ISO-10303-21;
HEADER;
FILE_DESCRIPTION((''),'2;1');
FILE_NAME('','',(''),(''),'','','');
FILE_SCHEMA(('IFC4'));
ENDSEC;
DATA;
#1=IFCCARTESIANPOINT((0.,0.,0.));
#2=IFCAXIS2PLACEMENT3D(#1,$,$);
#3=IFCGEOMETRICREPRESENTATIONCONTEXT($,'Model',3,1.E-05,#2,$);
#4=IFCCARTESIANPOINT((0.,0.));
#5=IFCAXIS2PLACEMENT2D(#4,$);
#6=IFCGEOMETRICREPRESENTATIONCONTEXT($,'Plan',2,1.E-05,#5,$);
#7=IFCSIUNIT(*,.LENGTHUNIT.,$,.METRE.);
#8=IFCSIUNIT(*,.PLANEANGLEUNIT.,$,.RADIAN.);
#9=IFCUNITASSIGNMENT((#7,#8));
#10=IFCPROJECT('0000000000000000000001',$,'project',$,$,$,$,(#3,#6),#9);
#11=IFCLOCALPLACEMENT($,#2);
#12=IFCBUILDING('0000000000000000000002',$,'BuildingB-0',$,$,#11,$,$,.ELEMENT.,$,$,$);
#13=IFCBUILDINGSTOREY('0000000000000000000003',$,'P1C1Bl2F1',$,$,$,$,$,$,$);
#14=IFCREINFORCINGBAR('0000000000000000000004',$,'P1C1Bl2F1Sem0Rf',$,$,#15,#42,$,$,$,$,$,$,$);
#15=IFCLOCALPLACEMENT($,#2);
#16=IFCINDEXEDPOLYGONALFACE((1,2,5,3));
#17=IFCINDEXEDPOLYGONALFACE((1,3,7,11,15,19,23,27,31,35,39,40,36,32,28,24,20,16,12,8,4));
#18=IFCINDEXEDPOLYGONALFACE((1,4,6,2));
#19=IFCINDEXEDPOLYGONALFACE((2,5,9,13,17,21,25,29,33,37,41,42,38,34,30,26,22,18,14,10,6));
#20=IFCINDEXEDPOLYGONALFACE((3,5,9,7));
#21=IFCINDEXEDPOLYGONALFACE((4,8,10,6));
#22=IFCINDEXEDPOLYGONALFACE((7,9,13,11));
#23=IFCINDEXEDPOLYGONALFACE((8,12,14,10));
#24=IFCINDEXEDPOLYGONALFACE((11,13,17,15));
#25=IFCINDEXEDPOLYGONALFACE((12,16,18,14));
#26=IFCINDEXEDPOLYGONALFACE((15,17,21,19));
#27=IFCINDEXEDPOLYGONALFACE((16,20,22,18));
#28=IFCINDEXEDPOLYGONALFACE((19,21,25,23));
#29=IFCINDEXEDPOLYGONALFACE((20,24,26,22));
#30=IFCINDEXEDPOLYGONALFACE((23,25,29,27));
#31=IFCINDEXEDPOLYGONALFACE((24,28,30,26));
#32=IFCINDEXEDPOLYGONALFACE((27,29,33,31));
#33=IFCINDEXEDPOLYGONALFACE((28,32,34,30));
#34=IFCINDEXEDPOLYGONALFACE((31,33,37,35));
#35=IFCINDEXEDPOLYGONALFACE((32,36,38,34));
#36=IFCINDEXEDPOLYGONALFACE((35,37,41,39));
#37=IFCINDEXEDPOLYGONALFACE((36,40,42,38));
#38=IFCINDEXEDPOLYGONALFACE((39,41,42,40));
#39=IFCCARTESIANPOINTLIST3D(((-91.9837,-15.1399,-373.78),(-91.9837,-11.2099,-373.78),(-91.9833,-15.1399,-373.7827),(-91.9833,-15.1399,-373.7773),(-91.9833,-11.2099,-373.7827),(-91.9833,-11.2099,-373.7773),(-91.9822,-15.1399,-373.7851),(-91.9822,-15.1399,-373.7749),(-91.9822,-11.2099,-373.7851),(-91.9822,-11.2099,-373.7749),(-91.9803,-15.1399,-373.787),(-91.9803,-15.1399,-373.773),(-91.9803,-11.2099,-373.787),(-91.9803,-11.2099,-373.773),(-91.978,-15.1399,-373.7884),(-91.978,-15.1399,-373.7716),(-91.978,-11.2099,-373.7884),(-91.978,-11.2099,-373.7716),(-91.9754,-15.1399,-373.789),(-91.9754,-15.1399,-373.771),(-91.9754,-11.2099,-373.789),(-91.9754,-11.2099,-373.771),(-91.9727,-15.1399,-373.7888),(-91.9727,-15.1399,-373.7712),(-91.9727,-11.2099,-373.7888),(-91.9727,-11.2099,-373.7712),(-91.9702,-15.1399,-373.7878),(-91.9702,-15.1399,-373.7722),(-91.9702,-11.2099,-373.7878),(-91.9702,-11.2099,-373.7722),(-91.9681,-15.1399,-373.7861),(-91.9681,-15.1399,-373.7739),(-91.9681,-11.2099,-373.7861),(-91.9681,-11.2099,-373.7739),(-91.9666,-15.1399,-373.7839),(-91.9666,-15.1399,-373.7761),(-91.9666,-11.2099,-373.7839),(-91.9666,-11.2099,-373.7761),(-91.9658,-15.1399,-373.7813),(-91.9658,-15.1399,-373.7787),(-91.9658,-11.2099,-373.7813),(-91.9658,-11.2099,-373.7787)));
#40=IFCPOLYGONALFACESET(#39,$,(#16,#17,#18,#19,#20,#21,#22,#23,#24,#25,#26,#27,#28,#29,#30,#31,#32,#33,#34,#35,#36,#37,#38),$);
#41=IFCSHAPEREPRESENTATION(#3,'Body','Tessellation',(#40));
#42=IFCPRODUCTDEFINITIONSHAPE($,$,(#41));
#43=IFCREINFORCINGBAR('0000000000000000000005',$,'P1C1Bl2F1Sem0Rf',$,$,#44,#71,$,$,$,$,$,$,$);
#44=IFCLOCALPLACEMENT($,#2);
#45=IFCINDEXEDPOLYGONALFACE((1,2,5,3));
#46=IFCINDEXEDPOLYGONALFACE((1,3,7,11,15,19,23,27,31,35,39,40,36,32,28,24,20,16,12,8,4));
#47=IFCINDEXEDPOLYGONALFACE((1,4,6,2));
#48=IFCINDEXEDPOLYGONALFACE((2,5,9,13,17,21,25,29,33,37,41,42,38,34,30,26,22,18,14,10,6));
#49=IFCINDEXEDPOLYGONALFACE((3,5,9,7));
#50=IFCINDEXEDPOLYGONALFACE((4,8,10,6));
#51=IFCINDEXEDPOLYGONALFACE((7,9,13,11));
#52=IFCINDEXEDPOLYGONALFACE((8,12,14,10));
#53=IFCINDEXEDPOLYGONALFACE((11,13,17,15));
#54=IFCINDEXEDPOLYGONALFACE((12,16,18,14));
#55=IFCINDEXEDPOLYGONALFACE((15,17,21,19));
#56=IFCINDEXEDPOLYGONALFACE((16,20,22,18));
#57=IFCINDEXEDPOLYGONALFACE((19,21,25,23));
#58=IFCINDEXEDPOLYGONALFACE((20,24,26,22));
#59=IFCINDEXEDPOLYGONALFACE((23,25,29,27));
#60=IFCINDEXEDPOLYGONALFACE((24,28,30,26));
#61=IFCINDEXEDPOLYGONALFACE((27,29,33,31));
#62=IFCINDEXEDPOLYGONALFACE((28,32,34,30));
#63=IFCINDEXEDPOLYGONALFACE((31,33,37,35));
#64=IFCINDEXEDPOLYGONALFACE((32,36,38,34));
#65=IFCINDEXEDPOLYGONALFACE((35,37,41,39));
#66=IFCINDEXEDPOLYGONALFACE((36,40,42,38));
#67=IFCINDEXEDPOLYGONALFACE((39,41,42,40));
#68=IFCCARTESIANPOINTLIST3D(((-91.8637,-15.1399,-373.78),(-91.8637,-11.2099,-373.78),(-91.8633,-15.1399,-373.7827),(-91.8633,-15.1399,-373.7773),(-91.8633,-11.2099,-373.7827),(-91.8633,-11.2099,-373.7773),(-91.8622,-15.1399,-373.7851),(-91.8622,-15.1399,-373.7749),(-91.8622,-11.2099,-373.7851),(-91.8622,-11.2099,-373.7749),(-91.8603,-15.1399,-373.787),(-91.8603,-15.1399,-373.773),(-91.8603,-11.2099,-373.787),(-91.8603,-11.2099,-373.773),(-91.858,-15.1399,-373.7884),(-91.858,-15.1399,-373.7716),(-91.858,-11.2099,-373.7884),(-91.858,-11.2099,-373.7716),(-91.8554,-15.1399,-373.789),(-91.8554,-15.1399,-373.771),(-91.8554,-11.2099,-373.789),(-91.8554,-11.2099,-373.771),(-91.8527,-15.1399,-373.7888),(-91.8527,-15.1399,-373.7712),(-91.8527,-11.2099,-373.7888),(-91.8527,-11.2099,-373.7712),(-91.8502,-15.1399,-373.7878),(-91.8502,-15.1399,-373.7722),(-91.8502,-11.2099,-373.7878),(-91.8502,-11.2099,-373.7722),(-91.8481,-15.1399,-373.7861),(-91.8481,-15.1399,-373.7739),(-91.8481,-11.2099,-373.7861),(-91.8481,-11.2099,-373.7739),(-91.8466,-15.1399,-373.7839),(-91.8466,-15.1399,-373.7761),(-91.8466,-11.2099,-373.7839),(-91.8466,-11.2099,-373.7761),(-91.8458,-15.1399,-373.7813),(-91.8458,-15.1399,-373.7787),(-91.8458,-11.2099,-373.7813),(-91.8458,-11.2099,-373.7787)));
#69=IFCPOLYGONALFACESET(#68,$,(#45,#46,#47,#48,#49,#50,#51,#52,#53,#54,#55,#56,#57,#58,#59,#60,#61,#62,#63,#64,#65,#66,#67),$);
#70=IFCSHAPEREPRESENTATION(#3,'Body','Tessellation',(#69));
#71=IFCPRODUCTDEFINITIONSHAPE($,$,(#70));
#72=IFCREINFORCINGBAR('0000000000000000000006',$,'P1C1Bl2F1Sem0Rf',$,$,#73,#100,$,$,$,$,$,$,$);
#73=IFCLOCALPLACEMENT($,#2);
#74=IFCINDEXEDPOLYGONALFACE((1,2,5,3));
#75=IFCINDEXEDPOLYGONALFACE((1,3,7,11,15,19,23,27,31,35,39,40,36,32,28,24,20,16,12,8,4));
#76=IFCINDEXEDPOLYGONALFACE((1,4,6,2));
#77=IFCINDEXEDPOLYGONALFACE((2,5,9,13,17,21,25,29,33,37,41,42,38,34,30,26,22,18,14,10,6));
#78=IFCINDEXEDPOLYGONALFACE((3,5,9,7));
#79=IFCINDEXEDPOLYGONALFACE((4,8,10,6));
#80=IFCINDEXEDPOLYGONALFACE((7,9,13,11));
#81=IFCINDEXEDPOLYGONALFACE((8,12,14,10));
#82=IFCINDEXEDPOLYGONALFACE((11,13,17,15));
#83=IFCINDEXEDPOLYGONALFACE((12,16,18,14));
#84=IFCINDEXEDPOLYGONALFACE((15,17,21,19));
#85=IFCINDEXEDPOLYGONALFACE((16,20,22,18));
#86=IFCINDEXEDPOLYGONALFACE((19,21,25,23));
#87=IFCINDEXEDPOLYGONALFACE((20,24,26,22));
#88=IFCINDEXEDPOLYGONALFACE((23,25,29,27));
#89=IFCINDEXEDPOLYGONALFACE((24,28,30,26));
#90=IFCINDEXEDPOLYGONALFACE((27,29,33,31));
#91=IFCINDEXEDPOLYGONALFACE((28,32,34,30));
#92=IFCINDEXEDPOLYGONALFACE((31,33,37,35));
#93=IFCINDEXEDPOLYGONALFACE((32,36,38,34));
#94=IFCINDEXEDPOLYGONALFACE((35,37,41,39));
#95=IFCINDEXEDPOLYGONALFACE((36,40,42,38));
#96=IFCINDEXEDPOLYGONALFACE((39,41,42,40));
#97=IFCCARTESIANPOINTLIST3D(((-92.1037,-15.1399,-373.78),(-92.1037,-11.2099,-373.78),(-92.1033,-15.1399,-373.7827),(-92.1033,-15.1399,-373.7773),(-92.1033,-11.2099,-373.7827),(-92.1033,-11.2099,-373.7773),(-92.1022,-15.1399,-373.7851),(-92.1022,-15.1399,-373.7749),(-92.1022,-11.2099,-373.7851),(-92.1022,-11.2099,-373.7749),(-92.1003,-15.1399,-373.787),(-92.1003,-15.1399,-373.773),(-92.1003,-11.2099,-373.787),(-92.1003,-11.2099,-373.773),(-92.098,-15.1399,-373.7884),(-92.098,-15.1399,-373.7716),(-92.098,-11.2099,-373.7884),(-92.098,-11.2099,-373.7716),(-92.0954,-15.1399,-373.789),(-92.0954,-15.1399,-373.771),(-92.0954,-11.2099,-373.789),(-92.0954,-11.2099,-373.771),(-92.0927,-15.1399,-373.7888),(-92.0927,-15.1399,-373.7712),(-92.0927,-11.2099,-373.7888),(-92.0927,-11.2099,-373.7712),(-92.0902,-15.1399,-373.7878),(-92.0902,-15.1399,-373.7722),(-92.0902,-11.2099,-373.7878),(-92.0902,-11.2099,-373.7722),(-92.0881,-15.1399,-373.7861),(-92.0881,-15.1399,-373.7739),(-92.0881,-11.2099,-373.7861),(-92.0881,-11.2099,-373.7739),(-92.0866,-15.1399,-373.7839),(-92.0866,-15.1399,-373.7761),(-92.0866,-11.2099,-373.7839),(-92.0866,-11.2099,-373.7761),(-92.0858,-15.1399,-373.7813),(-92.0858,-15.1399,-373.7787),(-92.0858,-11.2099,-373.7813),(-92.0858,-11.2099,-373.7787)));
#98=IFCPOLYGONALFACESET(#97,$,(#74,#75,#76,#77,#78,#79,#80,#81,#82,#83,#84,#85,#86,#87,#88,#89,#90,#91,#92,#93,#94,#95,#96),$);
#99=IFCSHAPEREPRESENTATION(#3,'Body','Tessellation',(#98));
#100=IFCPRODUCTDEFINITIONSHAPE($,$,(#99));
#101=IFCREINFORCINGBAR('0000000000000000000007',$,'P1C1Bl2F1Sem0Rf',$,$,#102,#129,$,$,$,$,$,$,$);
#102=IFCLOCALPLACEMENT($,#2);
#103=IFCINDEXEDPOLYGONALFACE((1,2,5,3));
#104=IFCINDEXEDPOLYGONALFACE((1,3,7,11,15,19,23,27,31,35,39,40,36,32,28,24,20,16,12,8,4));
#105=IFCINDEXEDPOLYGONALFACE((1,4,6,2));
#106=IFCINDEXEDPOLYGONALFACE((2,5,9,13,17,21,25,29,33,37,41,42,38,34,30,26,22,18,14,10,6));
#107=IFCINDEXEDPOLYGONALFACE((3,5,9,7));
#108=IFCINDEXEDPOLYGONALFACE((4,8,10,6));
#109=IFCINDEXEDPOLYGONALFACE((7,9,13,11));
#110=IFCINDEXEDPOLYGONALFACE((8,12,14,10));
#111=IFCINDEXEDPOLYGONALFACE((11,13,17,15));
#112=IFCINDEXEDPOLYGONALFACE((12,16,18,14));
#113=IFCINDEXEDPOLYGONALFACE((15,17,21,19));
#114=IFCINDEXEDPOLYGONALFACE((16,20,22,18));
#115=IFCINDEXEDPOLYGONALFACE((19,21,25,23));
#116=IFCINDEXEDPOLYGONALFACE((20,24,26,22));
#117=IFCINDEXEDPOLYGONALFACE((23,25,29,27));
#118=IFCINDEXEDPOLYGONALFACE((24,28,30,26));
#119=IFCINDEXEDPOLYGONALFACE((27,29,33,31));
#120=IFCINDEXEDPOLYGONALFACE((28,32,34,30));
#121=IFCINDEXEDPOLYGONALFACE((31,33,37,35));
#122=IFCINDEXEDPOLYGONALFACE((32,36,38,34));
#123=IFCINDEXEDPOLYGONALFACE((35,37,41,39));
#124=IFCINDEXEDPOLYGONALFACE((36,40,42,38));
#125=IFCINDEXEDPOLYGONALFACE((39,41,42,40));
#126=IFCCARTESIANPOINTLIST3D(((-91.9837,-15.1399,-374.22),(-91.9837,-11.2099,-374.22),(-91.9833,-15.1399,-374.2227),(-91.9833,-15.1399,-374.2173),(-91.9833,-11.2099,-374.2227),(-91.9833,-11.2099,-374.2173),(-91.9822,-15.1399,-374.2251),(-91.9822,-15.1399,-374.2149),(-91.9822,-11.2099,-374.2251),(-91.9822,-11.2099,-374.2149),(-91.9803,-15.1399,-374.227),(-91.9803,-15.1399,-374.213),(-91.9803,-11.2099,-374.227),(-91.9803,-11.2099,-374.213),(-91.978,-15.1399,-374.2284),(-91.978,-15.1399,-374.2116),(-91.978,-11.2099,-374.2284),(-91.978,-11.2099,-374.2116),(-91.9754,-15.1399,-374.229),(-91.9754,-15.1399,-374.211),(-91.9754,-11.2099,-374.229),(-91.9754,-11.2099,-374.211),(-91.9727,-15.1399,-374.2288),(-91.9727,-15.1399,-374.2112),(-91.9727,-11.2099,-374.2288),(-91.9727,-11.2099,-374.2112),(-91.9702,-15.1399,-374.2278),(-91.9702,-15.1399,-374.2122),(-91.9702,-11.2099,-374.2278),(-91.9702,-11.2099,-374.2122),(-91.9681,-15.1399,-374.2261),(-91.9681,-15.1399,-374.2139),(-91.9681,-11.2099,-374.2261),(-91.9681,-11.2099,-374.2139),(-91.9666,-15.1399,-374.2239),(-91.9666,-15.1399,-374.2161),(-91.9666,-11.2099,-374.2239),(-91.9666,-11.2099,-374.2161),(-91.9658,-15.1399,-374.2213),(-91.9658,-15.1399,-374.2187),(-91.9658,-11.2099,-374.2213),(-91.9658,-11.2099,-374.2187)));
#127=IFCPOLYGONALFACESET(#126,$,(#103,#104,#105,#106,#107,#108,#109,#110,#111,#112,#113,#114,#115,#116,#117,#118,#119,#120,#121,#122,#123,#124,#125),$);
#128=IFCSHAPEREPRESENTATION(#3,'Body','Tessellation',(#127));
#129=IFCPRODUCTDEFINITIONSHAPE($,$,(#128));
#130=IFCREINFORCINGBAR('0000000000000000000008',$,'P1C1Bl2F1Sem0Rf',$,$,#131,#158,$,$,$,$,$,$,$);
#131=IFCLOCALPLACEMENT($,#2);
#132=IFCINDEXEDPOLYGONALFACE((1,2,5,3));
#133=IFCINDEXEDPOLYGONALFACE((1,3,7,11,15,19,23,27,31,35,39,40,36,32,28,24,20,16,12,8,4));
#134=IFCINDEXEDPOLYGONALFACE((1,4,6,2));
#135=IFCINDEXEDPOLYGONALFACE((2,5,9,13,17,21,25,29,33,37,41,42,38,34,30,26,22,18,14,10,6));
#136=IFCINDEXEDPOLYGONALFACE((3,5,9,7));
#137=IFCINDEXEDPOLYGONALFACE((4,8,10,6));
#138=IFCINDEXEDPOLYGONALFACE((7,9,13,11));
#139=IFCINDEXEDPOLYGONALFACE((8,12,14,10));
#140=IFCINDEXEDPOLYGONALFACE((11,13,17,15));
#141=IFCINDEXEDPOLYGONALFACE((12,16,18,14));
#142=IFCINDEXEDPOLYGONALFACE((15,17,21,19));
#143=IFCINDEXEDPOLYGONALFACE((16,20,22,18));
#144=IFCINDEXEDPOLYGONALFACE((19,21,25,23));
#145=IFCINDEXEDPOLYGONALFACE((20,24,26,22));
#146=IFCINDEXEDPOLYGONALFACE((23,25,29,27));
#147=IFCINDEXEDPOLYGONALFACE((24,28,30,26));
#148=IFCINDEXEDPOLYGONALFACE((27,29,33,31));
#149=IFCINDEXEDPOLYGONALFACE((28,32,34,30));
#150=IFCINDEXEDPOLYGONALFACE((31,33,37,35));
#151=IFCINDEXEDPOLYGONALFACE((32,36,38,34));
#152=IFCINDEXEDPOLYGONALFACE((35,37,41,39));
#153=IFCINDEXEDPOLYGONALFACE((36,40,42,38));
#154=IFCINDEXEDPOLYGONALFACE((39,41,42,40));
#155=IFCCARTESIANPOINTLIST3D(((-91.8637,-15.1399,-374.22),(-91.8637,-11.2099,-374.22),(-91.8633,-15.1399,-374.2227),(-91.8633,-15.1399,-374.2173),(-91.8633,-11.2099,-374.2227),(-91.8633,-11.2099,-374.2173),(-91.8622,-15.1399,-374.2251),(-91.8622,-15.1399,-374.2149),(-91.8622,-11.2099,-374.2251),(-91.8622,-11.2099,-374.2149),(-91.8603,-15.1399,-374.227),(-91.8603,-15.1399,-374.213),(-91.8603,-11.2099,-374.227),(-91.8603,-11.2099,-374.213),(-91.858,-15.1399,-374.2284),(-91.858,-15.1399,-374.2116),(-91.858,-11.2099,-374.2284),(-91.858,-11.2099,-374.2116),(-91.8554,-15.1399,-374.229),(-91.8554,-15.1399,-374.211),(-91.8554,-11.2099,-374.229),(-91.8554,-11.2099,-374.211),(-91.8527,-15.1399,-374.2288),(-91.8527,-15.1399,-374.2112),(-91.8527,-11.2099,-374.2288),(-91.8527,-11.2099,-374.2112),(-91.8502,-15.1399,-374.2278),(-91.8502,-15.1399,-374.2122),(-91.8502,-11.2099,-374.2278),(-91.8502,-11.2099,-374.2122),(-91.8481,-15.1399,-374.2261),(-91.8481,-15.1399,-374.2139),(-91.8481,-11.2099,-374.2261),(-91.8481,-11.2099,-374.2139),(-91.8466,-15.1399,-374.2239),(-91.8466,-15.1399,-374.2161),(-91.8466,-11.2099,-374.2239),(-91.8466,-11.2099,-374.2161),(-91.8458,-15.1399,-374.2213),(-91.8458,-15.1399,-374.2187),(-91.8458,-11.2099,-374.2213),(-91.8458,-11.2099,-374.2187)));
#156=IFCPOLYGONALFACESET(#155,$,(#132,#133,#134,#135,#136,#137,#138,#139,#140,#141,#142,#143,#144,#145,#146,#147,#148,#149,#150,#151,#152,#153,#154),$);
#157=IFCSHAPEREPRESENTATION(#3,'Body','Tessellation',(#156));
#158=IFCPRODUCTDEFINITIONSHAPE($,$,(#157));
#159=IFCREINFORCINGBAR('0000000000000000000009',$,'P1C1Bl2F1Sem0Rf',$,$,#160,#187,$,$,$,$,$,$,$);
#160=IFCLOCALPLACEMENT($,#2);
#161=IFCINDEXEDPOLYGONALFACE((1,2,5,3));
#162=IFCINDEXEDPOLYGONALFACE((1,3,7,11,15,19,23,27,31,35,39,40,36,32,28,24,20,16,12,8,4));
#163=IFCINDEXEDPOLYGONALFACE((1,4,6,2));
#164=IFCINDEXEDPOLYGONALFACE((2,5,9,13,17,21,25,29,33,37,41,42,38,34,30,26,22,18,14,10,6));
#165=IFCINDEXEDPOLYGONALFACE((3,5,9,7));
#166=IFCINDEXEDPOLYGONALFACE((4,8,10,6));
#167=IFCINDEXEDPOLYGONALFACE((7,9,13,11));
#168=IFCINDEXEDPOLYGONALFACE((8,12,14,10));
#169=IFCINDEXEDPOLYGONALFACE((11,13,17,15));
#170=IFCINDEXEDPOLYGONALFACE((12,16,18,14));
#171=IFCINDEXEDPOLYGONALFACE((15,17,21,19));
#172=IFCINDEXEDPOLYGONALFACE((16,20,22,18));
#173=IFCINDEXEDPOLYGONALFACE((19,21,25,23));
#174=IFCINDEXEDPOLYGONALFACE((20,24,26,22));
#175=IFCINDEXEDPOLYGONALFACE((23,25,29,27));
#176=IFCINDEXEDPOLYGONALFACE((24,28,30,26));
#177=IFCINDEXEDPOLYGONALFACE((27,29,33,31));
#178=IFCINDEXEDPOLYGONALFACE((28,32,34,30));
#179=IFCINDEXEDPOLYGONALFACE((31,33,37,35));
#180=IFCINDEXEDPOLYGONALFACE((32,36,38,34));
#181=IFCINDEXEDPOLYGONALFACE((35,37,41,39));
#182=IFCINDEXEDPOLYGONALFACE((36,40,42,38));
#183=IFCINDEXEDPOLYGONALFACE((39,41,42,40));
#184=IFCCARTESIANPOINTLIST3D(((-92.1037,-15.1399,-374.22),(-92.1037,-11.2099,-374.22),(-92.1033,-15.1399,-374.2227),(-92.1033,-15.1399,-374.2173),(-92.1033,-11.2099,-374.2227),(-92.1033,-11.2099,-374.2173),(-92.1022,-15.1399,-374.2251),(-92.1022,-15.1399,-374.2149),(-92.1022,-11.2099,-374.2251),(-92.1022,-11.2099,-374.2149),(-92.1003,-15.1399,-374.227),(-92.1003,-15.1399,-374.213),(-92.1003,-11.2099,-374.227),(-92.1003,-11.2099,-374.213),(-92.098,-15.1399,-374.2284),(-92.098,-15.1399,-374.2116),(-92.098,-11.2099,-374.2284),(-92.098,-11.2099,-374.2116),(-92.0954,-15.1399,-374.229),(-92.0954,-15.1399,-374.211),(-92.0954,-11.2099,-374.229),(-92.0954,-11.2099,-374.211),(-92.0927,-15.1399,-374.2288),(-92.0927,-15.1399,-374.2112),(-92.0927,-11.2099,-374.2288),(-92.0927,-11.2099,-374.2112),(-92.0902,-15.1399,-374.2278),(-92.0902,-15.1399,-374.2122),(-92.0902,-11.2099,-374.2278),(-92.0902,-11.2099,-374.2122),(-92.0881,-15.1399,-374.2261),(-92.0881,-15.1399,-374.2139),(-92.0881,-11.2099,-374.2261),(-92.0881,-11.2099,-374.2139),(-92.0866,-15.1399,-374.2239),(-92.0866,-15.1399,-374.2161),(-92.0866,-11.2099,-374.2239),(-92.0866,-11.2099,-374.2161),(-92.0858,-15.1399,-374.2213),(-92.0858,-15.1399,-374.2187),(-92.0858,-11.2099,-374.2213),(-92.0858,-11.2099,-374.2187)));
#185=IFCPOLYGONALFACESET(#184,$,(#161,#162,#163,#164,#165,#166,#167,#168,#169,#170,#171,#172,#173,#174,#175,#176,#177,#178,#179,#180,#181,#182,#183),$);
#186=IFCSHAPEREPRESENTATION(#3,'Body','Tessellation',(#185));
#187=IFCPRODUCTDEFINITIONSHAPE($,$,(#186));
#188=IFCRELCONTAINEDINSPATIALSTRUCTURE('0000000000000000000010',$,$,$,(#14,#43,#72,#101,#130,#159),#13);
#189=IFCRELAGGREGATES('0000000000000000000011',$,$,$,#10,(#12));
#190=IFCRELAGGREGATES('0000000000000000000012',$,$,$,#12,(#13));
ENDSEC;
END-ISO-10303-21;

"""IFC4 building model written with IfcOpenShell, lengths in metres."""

from ifc_helpers import new_model, entity, si_unit, origin, origin_2d, place, context, project, spatial, element, save


model = new_model("IFC4")

# Units and contexts
model_context = context("Model", 3, precision=1e-05, world=origin())
plan_context = context("Plan", 2, precision=1e-05, world=origin_2d())
ifc_project = project(units=[si_unit("LENGTHUNIT", "METRE"), si_unit("PLANEANGLEUNIT", "RADIAN")], contexts=[model_context, plan_context])

# Building, storey
building_placement = place(None, origin())
building = spatial("IfcBuilding", under=ifc_project, at=building_placement, Name="BuildingB-0", CompositionType="ELEMENT")
storey = spatial("IfcBuildingStorey", under=building, Name="P1C1Bl2F1")

# Reinforcing bars
element("IfcReinforcingBar", 1, inside=storey, Name="P1C1Bl2F1Sem0Rf", context=model_context, shape_type="SweptSolid", body=[
    entity("IfcSurfaceCurveSweptAreaSolid", entity("IfcCircleProfileDef", "AREA", None, None, 0.009), None, entity("IfcPolyline", [entity("IfcCartesianPoint", [91.9747, 15.1399, 373.78]), entity("IfcCartesianPoint", [91.9747, 11.2099, 373.78])]), None, None, entity("IfcPlane", entity("IfcAxis2Placement3D", entity("IfcCartesianPoint", [91.9747, 15.1399, 373.78]), entity("IfcDirection", [0.0, 0.0, 1.0]), entity("IfcDirection", [1.0, 0.0, 0.0])))),
])
element("IfcReinforcingBar", 2, inside=storey, Name="P1C1Bl2F1Sem0Rf", context=model_context, shape_type="SweptSolid", body=[
    entity("IfcSurfaceCurveSweptAreaSolid", entity("IfcCircleProfileDef", "AREA", None, None, 0.009), None, entity("IfcPolyline", [entity("IfcCartesianPoint", [91.8547, 15.1399, 373.78]), entity("IfcCartesianPoint", [91.8547, 11.2099, 373.78])]), None, None, entity("IfcPlane", entity("IfcAxis2Placement3D", entity("IfcCartesianPoint", [91.8547, 15.1399, 373.78]), entity("IfcDirection", [0.0, 0.0, 1.0]), entity("IfcDirection", [1.0, 0.0, 0.0])))),
])
element("IfcReinforcingBar", 3, inside=storey, Name="P1C1Bl2F1Sem0Rf", context=model_context, shape_type="SweptSolid", body=[
    entity("IfcSurfaceCurveSweptAreaSolid", entity("IfcCircleProfileDef", "AREA", None, None, 0.009), None, entity("IfcPolyline", [entity("IfcCartesianPoint", [92.0947, 15.1399, 373.78]), entity("IfcCartesianPoint", [92.0947, 11.2099, 373.78])]), None, None, entity("IfcPlane", entity("IfcAxis2Placement3D", entity("IfcCartesianPoint", [92.0947, 15.1399, 373.78]), entity("IfcDirection", [0.0, 0.0, 1.0]), entity("IfcDirection", [1.0, 0.0, 0.0])))),
])
element("IfcReinforcingBar", 4, inside=storey, Name="P1C1Bl2F1Sem0Rf", context=model_context, shape_type="SweptSolid", body=[
    entity("IfcSurfaceCurveSweptAreaSolid", entity("IfcCircleProfileDef", "AREA", None, None, 0.009), None, entity("IfcPolyline", [entity("IfcCartesianPoint", [91.9747, 15.1399, 374.22]), entity("IfcCartesianPoint", [91.9747, 11.2099, 374.22])]), None, None, entity("IfcPlane", entity("IfcAxis2Placement3D", entity("IfcCartesianPoint", [91.9747, 15.1399, 374.22]), entity("IfcDirection", [0.0, 0.0, 1.0]), entity("IfcDirection", [1.0, 0.0, 0.0])))),
])
element("IfcReinforcingBar", 5, inside=storey, Name="P1C1Bl2F1Sem0Rf", context=model_context, shape_type="SweptSolid", body=[
    entity("IfcSurfaceCurveSweptAreaSolid", entity("IfcCircleProfileDef", "AREA", None, None, 0.009), None, entity("IfcPolyline", [entity("IfcCartesianPoint", [91.8547, 15.1399, 374.22]), entity("IfcCartesianPoint", [91.8547, 11.2099, 374.22])]), None, None, entity("IfcPlane", entity("IfcAxis2Placement3D", entity("IfcCartesianPoint", [91.8547, 15.1399, 374.22]), entity("IfcDirection", [0.0, 0.0, 1.0]), entity("IfcDirection", [1.0, 0.0, 0.0])))),
])
element("IfcReinforcingBar", 6, inside=storey, Name="P1C1Bl2F1Sem0Rf", context=model_context, shape_type="SweptSolid", body=[
    entity("IfcSurfaceCurveSweptAreaSolid", entity("IfcCircleProfileDef", "AREA", None, None, 0.009), None, entity("IfcPolyline", [entity("IfcCartesianPoint", [92.0947, 15.1399, 374.22]), entity("IfcCartesianPoint", [92.0947, 11.2099, 374.22])]), None, None, entity("IfcPlane", entity("IfcAxis2Placement3D", entity("IfcCartesianPoint", [92.0947, 15.1399, 374.22]), entity("IfcDirection", [0.0, 0.0, 1.0]), entity("IfcDirection", [1.0, 0.0, 0.0])))),
])

save(model, "model.ifc")
